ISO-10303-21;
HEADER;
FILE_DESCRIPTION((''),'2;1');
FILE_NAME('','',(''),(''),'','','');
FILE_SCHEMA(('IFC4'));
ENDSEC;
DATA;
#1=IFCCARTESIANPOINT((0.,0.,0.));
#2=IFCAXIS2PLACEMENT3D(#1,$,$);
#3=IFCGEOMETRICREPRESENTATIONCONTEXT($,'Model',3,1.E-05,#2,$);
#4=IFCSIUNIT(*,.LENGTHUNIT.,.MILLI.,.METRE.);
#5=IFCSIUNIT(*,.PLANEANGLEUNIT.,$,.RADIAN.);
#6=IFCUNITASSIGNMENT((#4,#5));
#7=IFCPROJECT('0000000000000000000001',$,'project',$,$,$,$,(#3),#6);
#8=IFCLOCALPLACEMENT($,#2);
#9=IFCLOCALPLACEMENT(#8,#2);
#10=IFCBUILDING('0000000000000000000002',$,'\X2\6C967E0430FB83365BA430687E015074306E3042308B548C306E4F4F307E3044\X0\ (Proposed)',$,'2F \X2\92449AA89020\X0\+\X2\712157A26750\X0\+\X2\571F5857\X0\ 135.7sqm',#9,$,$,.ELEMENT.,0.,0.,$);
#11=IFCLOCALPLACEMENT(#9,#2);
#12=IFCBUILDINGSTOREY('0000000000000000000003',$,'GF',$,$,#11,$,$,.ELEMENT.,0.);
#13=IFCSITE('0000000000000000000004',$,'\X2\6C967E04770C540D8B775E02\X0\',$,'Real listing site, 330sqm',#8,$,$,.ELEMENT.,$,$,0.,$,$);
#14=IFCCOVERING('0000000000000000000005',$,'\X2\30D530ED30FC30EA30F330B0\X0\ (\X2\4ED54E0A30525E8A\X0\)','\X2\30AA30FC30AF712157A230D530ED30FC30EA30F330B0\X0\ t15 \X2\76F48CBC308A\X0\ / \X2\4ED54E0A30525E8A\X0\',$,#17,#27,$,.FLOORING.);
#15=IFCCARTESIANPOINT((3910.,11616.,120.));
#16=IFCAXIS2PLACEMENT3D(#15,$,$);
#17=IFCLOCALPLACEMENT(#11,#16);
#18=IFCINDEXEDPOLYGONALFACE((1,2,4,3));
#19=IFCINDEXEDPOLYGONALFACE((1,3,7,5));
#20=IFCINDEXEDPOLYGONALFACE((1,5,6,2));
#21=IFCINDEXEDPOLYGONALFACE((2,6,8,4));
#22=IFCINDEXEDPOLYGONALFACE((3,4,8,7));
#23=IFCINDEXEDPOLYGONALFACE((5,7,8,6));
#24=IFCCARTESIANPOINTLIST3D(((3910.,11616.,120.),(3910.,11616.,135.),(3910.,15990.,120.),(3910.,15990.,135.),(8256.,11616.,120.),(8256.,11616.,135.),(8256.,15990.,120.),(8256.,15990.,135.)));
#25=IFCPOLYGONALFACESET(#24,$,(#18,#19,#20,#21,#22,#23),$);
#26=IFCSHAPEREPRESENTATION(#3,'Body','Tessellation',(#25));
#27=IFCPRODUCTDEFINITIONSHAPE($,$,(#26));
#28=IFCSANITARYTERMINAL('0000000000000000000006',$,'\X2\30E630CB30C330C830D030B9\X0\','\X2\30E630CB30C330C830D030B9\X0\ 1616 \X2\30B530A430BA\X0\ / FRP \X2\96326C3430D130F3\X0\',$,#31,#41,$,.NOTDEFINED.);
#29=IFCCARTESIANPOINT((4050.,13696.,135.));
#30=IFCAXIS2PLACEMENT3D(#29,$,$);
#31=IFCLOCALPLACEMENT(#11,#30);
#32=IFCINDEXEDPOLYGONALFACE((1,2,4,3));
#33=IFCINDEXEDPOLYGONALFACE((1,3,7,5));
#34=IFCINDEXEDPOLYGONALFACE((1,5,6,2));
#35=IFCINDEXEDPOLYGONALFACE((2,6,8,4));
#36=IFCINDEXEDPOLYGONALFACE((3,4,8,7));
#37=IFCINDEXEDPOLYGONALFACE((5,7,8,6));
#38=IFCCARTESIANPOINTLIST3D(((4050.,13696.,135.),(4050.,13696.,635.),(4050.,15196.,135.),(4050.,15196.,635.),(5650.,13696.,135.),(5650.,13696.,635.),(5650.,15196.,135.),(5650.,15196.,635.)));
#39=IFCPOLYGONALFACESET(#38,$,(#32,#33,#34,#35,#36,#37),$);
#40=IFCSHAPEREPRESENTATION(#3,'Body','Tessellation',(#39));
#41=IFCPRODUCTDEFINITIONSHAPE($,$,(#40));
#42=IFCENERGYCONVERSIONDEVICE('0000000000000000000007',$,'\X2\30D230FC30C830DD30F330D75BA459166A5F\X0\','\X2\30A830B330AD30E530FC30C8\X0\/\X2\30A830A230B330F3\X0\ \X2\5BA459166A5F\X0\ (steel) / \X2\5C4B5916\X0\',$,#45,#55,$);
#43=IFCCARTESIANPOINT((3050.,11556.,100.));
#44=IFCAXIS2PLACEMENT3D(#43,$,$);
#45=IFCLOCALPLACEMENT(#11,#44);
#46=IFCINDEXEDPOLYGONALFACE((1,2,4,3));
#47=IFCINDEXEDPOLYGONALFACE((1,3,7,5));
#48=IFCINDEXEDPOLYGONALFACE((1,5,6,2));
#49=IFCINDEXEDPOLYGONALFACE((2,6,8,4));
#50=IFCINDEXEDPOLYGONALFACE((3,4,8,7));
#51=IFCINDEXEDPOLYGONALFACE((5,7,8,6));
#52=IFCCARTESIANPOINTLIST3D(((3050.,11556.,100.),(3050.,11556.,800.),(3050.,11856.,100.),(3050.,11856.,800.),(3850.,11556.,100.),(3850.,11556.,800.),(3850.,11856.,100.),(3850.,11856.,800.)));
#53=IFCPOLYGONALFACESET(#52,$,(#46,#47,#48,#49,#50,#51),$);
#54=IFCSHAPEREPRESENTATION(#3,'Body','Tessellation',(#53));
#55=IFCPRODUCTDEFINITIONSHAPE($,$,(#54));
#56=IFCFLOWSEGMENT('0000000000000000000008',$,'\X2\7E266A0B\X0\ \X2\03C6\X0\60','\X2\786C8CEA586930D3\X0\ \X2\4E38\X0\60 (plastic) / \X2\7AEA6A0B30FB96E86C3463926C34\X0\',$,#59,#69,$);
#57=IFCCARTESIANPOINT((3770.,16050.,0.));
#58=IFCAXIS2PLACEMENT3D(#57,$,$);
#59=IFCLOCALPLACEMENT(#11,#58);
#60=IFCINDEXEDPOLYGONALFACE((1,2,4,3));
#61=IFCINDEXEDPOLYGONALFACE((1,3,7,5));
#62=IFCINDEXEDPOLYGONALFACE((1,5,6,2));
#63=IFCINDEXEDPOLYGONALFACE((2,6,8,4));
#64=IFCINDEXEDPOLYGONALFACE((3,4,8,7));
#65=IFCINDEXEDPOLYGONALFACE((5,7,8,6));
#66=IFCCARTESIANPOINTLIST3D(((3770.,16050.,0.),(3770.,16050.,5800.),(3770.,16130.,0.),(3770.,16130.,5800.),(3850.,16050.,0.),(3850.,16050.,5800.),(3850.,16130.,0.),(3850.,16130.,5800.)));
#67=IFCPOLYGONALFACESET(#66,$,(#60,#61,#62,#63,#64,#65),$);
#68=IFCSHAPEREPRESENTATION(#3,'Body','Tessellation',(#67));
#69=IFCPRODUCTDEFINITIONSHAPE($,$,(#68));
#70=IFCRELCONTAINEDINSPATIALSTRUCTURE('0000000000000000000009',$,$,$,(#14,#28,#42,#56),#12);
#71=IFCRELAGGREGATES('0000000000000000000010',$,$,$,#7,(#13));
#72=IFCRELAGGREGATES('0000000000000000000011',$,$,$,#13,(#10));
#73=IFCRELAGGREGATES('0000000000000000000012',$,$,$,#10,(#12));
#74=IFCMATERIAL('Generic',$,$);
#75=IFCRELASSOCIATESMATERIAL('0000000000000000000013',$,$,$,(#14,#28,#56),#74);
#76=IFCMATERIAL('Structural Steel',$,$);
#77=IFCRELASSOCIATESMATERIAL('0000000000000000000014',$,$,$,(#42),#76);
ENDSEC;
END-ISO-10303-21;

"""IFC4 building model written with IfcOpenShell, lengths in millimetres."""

from ifc_helpers import new_model, si_unit, frame, frame_2d, origin, place, context, project, spatial, rectangle, extrude, material, element, save


model = new_model("IFC4")

# Units and contexts
model_context = context("Model", 3, precision=1e-05, world=origin())
ifc_project = project(units=[si_unit("LENGTHUNIT", "METRE", prefix="MILLI"), si_unit("PLANEANGLEUNIT", "RADIAN")], contexts=[model_context])

# Site, building, storey
site_placement = place(None, origin())
site = spatial("IfcSite", under=ifc_project, at=site_placement, Name="沖縄県名護市", ObjectType="Real listing site, 330sqm", CompositionType="ELEMENT", RefElevation=0.0)
building_placement = place(site_placement, origin())
building = spatial("IfcBuilding", under=site, at=building_placement, Name="沖縄・茶室と縁側のある和の住まい (Proposed)", ObjectType="2F 鉄骨造+無垢材+土塗 135.7sqm", CompositionType="ELEMENT", ElevationOfRefHeight=0.0, ElevationOfTerrain=0.0)
storey_placement = place(building_placement, origin())
storey = spatial("IfcBuildingStorey", under=building, at=storey_placement, Name="GF", CompositionType="ELEMENT", Elevation=0.0)

# Covering
ifc_material_1 = material(Name="Generic")
covering_placement = place(storey_placement, frame((3910.0, 11616.0, 120.0)))
element("IfcCovering", 1, at=covering_placement, inside=storey, material=ifc_material_1, Name="フローリング (仕上げ床)", Description="オーク無垢フローリング t15 直貼り / 仕上げ床", PredefinedType="FLOORING", context=model_context, shape_type="SweptSolid", body=[
    extrude(rectangle(XDim=4346.0, YDim=4374.0, at=frame_2d((2173.0, 2187.0))), frame((3910.0, 11616.0, 120.0)), (0.0, 0.0, 1.0), 15.0),
])

# Sanitary terminal
sanitary_terminal_placement = place(storey_placement, frame((4050.0, 13696.0, 135.0)))
element("IfcSanitaryTerminal", 2, at=sanitary_terminal_placement, inside=storey, material=ifc_material_1, Name="ユニットバス", Description="ユニットバス 1616 サイズ / FRP 防水パン", PredefinedType="NOTDEFINED", context=model_context, shape_type="SweptSolid", body=[
    extrude(rectangle(XDim=1600.0, YDim=1500.0, at=frame_2d((800.0, 750.0))), frame((4050.0, 13696.0, 135.0)), (0.0, 0.0, 1.0), 500.0),
])

# Energy conversion device
ifc_material_2 = material(Name="Structural Steel")
energy_conversion_device_placement = place(storey_placement, frame((3050.0, 11556.0, 100.0)))
element("IfcEnergyConversionDevice", 3, at=energy_conversion_device_placement, inside=storey, material=ifc_material_2, Name="ヒートポンプ室外機", Description="エコキュート/エアコン 室外機 (steel) / 屋外", context=model_context, shape_type="SweptSolid", body=[
    extrude(rectangle(XDim=800.0, YDim=300.0, at=frame_2d((400.0, 150.0))), frame((3050.0, 11556.0, 100.0)), (0.0, 0.0, 1.0), 700.0),
])

# Flow segment
flow_segment_placement = place(storey_placement, frame((3770.0, 16050.0, 0.0)))
element("IfcFlowSegment", 4, at=flow_segment_placement, inside=storey, material=ifc_material_1, Name="縦樋 φ60", Description="硬質塩ビ 丸60 (plastic) / 竪樋・雨水排水", context=model_context, shape_type="SweptSolid", body=[
    extrude(rectangle(XDim=80.0, YDim=80.0, at=frame_2d((40.0, 40.0))), frame((3770.0, 16050.0, 0.0)), (0.0, 0.0, 1.0), 5800.0),
])

save(model, "model.ifc")
